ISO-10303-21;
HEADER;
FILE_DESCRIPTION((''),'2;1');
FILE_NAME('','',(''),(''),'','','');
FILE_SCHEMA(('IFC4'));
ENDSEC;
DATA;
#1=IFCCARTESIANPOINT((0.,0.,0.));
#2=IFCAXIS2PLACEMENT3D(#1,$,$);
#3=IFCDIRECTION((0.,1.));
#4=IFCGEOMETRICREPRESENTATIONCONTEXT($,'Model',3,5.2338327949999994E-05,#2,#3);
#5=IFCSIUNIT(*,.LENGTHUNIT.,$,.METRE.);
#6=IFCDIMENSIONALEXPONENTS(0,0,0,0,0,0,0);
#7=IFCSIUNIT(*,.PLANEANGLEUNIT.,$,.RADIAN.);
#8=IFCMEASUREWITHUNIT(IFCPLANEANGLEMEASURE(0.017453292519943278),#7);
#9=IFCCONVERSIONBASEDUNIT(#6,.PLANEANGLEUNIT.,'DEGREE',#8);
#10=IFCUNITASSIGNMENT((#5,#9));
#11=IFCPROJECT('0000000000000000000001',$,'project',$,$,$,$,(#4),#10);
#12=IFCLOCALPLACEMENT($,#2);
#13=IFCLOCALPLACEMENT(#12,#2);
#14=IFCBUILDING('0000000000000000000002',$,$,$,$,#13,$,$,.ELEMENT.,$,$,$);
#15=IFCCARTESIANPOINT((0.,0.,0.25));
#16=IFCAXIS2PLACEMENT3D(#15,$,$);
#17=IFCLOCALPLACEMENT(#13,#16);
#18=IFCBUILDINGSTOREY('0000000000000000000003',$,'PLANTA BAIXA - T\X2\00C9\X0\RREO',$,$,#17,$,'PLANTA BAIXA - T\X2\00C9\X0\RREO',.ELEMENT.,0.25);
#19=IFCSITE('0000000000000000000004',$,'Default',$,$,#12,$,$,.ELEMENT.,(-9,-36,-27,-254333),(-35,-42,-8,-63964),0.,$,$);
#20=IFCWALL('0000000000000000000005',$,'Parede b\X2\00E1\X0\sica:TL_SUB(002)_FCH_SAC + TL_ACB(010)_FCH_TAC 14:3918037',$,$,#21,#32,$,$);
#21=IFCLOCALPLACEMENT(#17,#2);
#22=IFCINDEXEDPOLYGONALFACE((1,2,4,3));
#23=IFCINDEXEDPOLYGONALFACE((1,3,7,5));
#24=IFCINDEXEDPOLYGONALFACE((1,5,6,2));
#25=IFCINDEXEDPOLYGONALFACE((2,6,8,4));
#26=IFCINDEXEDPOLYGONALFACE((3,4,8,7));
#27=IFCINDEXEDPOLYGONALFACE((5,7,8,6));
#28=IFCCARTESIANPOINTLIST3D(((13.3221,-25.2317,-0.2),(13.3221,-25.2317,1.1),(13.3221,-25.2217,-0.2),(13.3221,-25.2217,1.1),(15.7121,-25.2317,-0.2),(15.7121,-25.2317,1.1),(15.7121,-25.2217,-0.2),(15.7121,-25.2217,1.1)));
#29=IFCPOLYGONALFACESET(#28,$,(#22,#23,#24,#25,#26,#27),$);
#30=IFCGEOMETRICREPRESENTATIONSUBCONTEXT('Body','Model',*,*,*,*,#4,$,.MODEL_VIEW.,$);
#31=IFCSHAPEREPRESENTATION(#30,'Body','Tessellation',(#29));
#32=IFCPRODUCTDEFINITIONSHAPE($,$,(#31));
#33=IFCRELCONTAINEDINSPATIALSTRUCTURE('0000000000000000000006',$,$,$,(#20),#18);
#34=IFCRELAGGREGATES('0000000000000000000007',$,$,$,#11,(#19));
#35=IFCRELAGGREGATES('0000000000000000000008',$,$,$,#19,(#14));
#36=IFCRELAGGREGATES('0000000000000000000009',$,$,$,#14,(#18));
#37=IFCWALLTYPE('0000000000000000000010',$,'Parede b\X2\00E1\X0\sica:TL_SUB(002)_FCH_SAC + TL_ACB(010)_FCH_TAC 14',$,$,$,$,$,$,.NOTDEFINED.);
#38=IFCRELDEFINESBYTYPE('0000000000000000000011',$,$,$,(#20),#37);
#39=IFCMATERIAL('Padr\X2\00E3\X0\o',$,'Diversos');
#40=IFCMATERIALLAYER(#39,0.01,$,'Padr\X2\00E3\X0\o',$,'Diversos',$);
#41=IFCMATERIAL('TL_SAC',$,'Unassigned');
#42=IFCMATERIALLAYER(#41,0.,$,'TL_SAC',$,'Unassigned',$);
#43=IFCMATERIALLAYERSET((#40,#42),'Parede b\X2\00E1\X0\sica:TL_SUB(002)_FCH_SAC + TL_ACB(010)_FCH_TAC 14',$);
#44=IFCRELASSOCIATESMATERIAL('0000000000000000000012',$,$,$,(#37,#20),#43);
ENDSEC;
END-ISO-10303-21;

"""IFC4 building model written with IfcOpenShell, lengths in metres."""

from ifc_helpers import new_model, entity, si_unit, converted_unit, direction, frame, frame_2d, origin, place, context, subcontext, project, spatial, rectangle, extrude, material, layer, layer_set, layer_usage, type_object, element, save


model = new_model("IFC4")

# Units and contexts
model_context = context("Model", 3, precision=5.2338327949999994e-05, world=origin(), true_north=direction((0.0, 1.0)))
body_context = subcontext(model_context, "Body", "Model", "MODEL_VIEW")
ifc_project = project(units=[si_unit("LENGTHUNIT", "METRE"), converted_unit("PLANEANGLEUNIT", "DEGREE", entity("IfcPlaneAngleMeasure", 0.017453292519943278), si_unit("PLANEANGLEUNIT", "RADIAN"), dimensions=[0, 0, 0, 0, 0, 0, 0])], contexts=[model_context])

# Site, building, storey
site_placement = place(None, frame((0.0, 0.0, 0.0)))
site = spatial("IfcSite", under=ifc_project, at=site_placement, Name="Default", CompositionType="ELEMENT", RefLatitude=(-9, -36, -27, -254333), RefLongitude=(-35, -42, -8, -63964), RefElevation=0.0)
building_placement = place(site_placement, origin())
building = spatial("IfcBuilding", under=site, at=building_placement, CompositionType="ELEMENT")
storey_placement = place(building_placement, frame((0.0, 0.0, 0.25)))
storey = spatial("IfcBuildingStorey", under=building, at=storey_placement, Name="PLANTA BAIXA - TÉRREO", LongName="PLANTA BAIXA - TÉRREO", CompositionType="ELEMENT", Elevation=0.25)

# Shared definitions
ifc_material_1 = material(Name="TL_SAC", Category="Unassigned")

# Wall
ifc_material_2 = material(Name="Padrão", Category="Diversos")
ifc_layer_1 = layer(ifc_material_2, 0.01, Name="Padrão", Category="Diversos")
ifc_layer_2 = layer(ifc_material_1, 0.0, Name="TL_SAC", Category="Unassigned")
ifc_layer_set_1 = layer_set([ifc_layer_1, ifc_layer_2], Name="Parede básica:TL_SUB(002)_FCH_SAC + TL_ACB(010)_FCH_TAC 14")
ifc_layer_usage_1 = layer_usage(ifc_layer_set_1, "AXIS2", "NEGATIVE", 0.005)
wall_type_1 = type_object("IfcWallType", Name="Parede básica:TL_SUB(002)_FCH_SAC + TL_ACB(010)_FCH_TAC 14", PredefinedType="NOTDEFINED", material=ifc_layer_set_1)
wall_1_placement = place(storey_placement, frame((13.3221, -25.2267, -0.2)))
element("IfcWall", 1, at=wall_1_placement, inside=storey, type_object=wall_type_1, material=ifc_layer_usage_1, Name="Parede básica:TL_SUB(002)_FCH_SAC + TL_ACB(010)_FCH_TAC 14:3918037", context=body_context, shape_type="SweptSolid", body=[
    extrude(rectangle(XDim=2.39, YDim=0.01, at=frame_2d((1.195, 0.0), x_axis=(-1.0, 0.0))), origin(), (0.0, 0.0, 1.0), 1.3),
])

save(model, "model.ifc")
